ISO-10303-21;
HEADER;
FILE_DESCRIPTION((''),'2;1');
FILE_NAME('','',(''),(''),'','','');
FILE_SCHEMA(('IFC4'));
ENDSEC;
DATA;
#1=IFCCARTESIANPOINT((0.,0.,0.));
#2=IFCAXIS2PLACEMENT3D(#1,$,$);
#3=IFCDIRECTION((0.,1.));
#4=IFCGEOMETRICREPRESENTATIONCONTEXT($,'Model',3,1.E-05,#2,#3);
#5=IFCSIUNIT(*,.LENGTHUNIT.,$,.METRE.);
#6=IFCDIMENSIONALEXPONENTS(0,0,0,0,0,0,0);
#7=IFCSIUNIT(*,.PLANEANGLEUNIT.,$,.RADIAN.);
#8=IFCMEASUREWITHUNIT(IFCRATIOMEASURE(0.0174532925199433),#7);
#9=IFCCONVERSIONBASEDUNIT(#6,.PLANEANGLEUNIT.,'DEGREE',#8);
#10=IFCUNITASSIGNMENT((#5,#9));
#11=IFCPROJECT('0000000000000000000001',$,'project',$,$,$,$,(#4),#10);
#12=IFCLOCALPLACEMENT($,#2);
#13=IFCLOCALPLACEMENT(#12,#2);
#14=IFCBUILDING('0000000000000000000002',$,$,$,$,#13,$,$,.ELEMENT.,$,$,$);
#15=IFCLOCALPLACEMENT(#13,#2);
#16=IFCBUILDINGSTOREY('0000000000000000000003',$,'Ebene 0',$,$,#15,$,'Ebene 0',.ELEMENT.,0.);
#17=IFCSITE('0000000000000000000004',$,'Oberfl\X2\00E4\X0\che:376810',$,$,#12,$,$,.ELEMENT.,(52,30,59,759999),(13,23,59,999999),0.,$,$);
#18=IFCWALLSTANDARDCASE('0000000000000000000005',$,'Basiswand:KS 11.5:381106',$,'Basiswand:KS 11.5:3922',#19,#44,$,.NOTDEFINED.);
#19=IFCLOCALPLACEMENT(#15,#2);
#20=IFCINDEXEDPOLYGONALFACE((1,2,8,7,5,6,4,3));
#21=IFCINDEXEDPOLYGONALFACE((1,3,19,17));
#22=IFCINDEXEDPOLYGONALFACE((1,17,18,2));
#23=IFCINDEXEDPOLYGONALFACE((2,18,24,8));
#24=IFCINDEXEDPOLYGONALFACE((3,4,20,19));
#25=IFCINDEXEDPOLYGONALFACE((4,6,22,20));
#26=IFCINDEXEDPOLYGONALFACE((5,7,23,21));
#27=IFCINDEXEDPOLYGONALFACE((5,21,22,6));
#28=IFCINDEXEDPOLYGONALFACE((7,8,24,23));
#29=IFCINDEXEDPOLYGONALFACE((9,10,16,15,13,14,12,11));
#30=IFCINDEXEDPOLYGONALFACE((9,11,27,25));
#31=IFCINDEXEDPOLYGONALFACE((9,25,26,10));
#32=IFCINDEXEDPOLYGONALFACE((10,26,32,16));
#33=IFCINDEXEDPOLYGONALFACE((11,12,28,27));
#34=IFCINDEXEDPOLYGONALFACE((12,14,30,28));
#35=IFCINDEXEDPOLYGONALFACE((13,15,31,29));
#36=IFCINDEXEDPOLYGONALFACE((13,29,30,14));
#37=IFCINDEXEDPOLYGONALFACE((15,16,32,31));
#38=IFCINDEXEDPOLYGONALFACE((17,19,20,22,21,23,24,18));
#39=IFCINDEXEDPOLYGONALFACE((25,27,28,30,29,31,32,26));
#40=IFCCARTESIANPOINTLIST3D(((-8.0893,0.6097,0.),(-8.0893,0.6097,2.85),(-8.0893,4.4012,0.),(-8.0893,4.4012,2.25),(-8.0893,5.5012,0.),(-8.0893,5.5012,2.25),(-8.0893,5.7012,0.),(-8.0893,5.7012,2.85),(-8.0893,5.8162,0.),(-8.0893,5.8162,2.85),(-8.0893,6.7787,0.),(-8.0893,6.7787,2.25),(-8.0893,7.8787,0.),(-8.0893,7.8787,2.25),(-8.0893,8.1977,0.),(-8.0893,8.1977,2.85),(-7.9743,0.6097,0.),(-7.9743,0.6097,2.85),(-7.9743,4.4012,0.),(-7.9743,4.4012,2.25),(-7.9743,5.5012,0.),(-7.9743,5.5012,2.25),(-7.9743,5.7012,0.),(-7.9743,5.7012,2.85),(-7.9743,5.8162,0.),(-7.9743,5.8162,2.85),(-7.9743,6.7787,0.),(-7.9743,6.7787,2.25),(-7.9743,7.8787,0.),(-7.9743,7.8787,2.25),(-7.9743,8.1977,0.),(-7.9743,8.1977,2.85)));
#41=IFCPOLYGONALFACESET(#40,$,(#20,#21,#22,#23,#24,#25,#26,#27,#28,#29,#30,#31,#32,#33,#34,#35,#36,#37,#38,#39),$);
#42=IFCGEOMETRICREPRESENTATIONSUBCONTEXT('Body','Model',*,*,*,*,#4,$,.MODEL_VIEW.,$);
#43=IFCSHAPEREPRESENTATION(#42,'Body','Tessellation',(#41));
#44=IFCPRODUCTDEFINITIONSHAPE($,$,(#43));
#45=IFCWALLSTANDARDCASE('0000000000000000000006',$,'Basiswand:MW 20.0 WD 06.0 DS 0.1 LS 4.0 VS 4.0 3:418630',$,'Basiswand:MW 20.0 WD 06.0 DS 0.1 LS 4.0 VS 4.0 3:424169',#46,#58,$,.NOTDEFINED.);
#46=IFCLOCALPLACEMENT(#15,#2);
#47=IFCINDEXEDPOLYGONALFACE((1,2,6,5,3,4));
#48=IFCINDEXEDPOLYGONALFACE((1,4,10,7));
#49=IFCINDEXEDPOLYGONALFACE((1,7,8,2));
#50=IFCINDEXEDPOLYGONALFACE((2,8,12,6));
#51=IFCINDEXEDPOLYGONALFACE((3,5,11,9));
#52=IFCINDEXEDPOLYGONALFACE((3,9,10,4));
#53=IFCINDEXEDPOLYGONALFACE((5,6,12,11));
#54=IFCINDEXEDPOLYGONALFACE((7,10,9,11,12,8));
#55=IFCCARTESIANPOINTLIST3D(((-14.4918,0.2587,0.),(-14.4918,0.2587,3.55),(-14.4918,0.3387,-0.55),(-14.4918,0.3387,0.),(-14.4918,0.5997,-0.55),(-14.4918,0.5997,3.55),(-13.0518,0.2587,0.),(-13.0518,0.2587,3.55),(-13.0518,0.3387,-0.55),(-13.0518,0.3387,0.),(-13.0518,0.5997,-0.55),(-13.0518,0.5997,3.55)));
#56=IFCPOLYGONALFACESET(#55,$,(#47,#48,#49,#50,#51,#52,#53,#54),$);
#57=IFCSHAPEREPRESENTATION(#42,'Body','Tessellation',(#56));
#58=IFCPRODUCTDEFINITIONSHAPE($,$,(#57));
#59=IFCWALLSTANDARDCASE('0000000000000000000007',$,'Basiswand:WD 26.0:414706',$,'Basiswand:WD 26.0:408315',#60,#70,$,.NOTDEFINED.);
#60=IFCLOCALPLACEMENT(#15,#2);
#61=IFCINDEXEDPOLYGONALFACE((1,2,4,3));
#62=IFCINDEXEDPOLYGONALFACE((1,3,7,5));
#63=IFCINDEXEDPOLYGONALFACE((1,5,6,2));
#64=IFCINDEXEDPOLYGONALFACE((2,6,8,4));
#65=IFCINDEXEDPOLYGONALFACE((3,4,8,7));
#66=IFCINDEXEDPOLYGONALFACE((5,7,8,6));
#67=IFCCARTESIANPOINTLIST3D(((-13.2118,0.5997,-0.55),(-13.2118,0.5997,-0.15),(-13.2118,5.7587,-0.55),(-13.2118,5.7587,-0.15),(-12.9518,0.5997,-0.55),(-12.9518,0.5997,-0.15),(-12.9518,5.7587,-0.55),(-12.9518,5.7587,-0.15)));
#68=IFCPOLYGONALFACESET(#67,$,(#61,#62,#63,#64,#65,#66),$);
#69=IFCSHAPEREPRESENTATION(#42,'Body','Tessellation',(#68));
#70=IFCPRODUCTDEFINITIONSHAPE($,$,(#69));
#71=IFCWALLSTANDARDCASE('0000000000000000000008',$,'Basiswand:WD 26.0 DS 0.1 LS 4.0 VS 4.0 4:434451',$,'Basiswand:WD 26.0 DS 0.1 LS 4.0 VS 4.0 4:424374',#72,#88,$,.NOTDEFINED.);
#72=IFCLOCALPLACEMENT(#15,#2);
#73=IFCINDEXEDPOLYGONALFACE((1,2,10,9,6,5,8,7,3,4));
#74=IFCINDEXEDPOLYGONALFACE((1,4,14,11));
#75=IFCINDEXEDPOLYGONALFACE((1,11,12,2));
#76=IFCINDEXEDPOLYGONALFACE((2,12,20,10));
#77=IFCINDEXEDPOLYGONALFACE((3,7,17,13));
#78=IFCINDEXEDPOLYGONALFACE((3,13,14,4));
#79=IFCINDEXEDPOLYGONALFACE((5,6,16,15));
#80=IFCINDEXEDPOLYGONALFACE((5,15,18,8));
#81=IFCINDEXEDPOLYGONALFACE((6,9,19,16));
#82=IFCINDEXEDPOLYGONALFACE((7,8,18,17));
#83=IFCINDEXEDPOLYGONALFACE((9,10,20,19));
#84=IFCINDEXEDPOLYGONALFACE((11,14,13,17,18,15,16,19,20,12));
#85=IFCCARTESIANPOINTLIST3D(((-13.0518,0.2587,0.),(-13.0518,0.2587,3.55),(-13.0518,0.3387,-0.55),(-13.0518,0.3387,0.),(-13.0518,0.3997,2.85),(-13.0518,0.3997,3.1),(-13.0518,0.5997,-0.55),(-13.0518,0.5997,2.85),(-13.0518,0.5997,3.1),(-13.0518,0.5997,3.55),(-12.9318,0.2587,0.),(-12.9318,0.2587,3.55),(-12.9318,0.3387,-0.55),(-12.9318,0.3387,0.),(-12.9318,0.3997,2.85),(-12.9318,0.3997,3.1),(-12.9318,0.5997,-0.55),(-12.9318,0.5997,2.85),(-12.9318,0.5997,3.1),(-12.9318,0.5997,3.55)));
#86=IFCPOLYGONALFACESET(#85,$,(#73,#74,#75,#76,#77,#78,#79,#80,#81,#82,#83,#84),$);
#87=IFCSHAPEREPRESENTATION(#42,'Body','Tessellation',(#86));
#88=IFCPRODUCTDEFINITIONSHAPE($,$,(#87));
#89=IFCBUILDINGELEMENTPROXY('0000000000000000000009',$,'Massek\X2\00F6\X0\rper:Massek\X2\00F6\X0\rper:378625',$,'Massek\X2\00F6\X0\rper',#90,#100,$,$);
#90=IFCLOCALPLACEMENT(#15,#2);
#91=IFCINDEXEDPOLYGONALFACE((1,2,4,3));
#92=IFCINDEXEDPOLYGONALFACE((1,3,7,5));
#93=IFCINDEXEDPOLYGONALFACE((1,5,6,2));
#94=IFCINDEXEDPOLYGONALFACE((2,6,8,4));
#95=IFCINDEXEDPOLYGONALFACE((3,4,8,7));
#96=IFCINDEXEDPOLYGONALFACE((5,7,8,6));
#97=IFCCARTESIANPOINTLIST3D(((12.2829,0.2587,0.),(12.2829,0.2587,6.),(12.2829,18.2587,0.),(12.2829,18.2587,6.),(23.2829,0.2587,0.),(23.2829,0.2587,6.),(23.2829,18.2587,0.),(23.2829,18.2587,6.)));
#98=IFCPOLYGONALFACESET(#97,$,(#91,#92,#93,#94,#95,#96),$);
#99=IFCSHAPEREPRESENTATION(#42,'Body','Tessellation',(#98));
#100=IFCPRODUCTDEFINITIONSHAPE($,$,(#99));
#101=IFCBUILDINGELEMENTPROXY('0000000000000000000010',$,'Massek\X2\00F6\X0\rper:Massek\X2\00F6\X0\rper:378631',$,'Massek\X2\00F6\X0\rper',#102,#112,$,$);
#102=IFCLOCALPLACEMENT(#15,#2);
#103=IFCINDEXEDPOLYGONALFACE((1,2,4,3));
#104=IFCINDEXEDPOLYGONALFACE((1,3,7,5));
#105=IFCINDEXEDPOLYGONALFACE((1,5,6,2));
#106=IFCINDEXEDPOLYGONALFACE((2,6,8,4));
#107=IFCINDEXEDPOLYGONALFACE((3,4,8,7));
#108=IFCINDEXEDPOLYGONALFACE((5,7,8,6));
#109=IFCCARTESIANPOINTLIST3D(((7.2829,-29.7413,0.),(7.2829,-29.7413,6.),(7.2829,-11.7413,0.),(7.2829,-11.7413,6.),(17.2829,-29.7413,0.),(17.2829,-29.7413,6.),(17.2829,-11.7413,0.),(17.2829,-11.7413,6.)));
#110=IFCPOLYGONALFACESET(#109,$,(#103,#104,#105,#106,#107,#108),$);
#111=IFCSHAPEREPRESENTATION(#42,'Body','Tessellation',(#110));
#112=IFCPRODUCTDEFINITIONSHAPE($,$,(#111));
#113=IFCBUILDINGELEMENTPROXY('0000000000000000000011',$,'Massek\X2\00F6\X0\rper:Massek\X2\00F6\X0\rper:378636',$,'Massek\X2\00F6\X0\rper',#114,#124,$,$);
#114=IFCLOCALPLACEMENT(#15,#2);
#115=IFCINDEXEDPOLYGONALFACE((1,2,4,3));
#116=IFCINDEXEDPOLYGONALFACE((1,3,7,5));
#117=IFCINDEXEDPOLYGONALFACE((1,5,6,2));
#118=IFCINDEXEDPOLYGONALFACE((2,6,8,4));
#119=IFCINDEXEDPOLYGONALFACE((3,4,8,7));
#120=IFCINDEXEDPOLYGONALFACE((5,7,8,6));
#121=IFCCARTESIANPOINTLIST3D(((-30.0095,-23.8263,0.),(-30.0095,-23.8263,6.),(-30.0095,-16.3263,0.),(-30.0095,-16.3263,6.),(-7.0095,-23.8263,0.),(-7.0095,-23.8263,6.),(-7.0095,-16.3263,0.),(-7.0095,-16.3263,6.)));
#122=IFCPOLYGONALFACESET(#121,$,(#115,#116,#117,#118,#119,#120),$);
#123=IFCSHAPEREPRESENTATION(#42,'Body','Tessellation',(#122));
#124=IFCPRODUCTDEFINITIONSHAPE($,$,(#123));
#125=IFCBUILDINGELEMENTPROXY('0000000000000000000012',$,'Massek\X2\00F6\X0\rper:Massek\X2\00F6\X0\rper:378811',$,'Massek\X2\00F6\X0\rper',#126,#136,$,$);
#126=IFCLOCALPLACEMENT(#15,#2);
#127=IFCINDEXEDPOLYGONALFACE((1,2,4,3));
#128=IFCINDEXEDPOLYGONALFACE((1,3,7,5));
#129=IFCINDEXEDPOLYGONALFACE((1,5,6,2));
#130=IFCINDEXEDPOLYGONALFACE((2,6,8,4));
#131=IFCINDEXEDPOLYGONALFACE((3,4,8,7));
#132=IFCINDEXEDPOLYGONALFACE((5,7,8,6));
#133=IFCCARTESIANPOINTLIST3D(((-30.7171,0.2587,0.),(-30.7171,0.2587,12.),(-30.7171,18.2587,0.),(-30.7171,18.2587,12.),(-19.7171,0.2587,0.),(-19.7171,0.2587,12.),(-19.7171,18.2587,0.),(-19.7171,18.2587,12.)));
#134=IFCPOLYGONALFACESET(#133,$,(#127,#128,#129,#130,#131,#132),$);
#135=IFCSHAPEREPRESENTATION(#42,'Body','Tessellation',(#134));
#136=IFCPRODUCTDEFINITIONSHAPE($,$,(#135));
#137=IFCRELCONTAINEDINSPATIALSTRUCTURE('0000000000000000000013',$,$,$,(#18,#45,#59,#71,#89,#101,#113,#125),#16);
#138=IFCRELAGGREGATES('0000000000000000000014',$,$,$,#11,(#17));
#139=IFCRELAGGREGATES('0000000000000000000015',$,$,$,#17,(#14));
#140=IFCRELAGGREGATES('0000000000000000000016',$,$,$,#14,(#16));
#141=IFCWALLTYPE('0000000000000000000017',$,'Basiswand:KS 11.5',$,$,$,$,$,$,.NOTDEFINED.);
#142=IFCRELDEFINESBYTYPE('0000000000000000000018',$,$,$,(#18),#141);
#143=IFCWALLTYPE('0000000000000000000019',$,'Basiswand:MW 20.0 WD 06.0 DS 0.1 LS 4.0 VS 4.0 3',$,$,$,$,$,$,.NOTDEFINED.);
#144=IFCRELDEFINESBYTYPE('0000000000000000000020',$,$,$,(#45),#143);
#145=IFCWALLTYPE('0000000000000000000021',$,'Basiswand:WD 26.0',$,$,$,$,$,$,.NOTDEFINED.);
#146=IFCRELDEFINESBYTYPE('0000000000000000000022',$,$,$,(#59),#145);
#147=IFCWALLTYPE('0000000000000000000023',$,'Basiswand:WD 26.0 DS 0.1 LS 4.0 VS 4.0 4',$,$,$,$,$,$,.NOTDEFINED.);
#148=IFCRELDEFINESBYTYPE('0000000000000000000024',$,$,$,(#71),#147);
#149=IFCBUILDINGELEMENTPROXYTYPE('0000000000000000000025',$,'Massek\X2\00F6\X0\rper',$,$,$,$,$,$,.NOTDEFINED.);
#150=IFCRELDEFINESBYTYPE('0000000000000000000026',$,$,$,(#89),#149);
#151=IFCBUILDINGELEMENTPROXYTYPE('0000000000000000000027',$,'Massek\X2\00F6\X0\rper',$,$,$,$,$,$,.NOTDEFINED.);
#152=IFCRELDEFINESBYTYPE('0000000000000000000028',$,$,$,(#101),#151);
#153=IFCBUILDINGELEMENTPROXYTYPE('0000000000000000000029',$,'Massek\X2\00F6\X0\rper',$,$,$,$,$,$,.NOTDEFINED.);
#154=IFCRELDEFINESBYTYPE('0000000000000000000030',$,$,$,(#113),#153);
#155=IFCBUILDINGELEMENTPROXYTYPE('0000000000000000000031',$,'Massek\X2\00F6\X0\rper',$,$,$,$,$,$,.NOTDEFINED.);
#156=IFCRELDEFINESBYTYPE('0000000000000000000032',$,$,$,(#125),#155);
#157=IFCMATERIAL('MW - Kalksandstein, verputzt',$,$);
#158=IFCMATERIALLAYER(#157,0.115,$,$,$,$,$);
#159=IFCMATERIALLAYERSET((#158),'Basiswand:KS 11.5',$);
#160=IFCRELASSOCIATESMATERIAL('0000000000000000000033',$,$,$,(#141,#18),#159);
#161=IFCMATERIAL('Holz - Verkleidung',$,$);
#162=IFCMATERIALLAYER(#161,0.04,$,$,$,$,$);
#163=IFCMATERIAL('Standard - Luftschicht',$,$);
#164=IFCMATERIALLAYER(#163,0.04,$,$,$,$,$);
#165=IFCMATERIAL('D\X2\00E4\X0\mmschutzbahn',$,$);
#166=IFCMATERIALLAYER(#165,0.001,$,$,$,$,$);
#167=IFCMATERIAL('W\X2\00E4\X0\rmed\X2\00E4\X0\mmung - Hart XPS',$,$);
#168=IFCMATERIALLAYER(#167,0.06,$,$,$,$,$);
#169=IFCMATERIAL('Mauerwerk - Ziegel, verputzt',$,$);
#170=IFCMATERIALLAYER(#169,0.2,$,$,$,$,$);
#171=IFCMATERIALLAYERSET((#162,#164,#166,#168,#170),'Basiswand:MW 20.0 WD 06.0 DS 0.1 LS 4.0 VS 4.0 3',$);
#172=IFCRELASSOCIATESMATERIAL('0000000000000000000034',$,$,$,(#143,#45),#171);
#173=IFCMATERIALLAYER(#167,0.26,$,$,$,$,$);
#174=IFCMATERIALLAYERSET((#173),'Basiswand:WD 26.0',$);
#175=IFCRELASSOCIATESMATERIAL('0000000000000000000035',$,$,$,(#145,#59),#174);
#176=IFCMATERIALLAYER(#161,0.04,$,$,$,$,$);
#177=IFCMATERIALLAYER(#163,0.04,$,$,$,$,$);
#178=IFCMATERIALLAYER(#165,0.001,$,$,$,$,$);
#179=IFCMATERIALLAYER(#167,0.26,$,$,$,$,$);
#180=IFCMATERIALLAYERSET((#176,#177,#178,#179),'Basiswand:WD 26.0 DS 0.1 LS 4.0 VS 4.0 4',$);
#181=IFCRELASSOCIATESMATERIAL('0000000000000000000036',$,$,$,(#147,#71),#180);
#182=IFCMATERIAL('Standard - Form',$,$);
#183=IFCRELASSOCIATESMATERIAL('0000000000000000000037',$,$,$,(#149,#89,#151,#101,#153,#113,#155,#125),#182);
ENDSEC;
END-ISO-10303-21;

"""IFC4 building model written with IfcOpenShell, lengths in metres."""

from ifc_helpers import new_model, entity, si_unit, converted_unit, direction, frame, frame_2d, origin, origin_2d_with_axis, place, context, subcontext, project, spatial, polyline, rectangle, extrude, clip, bounded_halfspace, source, transform, mapped, material, layer, layer_set, layer_usage, type_object, type_shapes, element, save


model = new_model("IFC4")

# Units and contexts
model_context = context("Model", 3, precision=1e-05, world=origin(), true_north=direction((0.0, 1.0)))
body_context = subcontext(model_context, "Body", "Model", "MODEL_VIEW")
ifc_project = project(units=[si_unit("LENGTHUNIT", "METRE"), converted_unit("PLANEANGLEUNIT", "DEGREE", entity("IfcRatioMeasure", 0.0174532925199433), si_unit("PLANEANGLEUNIT", "RADIAN"), dimensions=[0, 0, 0, 0, 0, 0, 0])], contexts=[model_context])

# Site, building, storey
site_placement = place(None, origin())
site = spatial("IfcSite", under=ifc_project, at=site_placement, Name="Oberfläche:376810", CompositionType="ELEMENT", RefLatitude=(52, 30, 59, 759999), RefLongitude=(13, 23, 59, 999999), RefElevation=0.0)
building_placement = place(site_placement, origin())
building = spatial("IfcBuilding", under=site, at=building_placement, CompositionType="ELEMENT")
storey_placement = place(building_placement, origin())
storey = spatial("IfcBuildingStorey", under=building, at=storey_placement, Name="Ebene 0", LongName="Ebene 0", CompositionType="ELEMENT", Elevation=0.0)

# Shared definitions
ifc_material_1 = material(Name="Wärmedämmung - Hart XPS")

# Shared definitions
ifc_material_2 = material(Name="MW - Kalksandstein, verputzt")
ifc_layer_1 = layer(ifc_material_2, 0.115)
ifc_layer_set_1 = layer_set([ifc_layer_1], Name="Basiswand:KS 11.5")
wall_type_1 = type_object("IfcWallType", Name="Basiswand:KS 11.5", PredefinedType="NOTDEFINED", material=ifc_layer_set_1)

# Wall, openings
ifc_layer_usage_1 = layer_usage(ifc_layer_set_1, "AXIS2", "NEGATIVE", 0.0575)
wall_1_placement = place(storey_placement, frame((-8.0318, 0.6097, 0.0), z_axis=(0.0, 0.0, 1.0), x_axis=(0.0, 1.0, 0.0)))
wall_1 = element("IfcWallStandardCase", 1, at=wall_1_placement, inside=storey, type_object=wall_type_1, material=ifc_layer_usage_1, Name="Basiswand:KS 11.5:381106", ObjectType="Basiswand:KS 11.5:3922", PredefinedType="NOTDEFINED", context=body_context, shape_type="SweptSolid", body=[
    extrude(rectangle(XDim=7.588, YDim=0.115, at=frame_2d((3.794, 0.0), x_axis=(-1.0, 0.0))), origin(), (0.0, 0.0, 1.0), 2.85),
])
opening_1_placement = place(storey_placement, frame((-8.0318, 0.6097, 0.0), z_axis=(0.0, 0.0, 1.0), x_axis=(0.0, 1.0, 0.0)))
element("IfcOpeningElement", 2, at=opening_1_placement, cuts=wall_1, ObjectType="Opening", PredefinedType="OPENING", context=body_context, shape_type="SweptSolid", body=[
    extrude(rectangle(XDim=2.85, YDim=0.115, at=frame_2d((0.0, 0.0), x_axis=(1.0, 0.0))), frame((5.0915, 0.0, 1.425), z_axis=(1.0, 0.0, 0.0), x_axis=(0.0, 0.0, -1.0)), (0.0, 0.0, 1.0), 0.115),
])
opening_2_placement = place(wall_1_placement, frame((7.269, 0.0575, 0.0)))
element("IfcOpeningElement", 3, at=opening_2_placement, cuts=wall_1, ObjectType="Opening", PredefinedType="OPENING", context=body_context, shape_type="SweptSolid", body=[
    extrude(rectangle(XDim=2.25, YDim=1.1, at=frame_2d((1.125, 0.55), x_axis=(1.0, 0.0))), frame((0.0, 0.0, 0.0), z_axis=(0.0, -1.0, 0.0), x_axis=(0.0, 0.0, 1.0)), (0.0, 0.0, 1.0), 0.115),
])
opening_3_placement = place(wall_1_placement, frame((4.8915, 0.0575, 0.0)))
element("IfcOpeningElement", 4, at=opening_3_placement, cuts=wall_1, ObjectType="Opening", PredefinedType="OPENING", context=body_context, shape_type="SweptSolid", body=[
    extrude(rectangle(XDim=2.25, YDim=1.1, at=frame_2d((1.125, 0.55), x_axis=(1.0, 0.0))), frame((0.0, 0.0, 0.0), z_axis=(0.0, -1.0, 0.0), x_axis=(0.0, 0.0, 1.0)), (0.0, 0.0, 1.0), 0.115),
])

# Walls
ifc_material_3 = material(Name="Holz - Verkleidung")
ifc_layer_2 = layer(ifc_material_3, 0.04)
ifc_material_4 = material(Name="Standard - Luftschicht")
ifc_layer_3 = layer(ifc_material_4, 0.04)
ifc_material_5 = material(Name="Dämmschutzbahn")
ifc_layer_4 = layer(ifc_material_5, 0.001)
ifc_layer_5 = layer(ifc_material_1, 0.06)
ifc_material_6 = material(Name="Mauerwerk - Ziegel, verputzt")
ifc_layer_6 = layer(ifc_material_6, 0.2)
ifc_layer_set_2 = layer_set([ifc_layer_2, ifc_layer_3, ifc_layer_4, ifc_layer_5, ifc_layer_6], Name="Basiswand:MW 20.0 WD 06.0 DS 0.1 LS 4.0 VS 4.0 3")
ifc_layer_usage_2 = layer_usage(ifc_layer_set_2, "AXIS2", "NEGATIVE", 0.1705)
wall_type_2 = type_object("IfcWallType", Name="Basiswand:MW 20.0 WD 06.0 DS 0.1 LS 4.0 VS 4.0 3", PredefinedType="NOTDEFINED", material=ifc_layer_set_2)
wall_2_placement = place(storey_placement, frame((-13.0518, 0.4292, -0.55), z_axis=(0.0, 0.0, 1.0), x_axis=(-1.0, 0.0, 0.0)))
element("IfcWallStandardCase", 5, at=wall_2_placement, inside=storey, type_object=wall_type_2, material=ifc_layer_usage_2, Name="Basiswand:MW 20.0 WD 06.0 DS 0.1 LS 4.0 VS 4.0 3:418630", ObjectType="Basiswand:MW 20.0 WD 06.0 DS 0.1 LS 4.0 VS 4.0 3:424169", PredefinedType="NOTDEFINED", context=body_context, shape_type="Clipping", body=[
    clip(extrude(rectangle(XDim=1.44, YDim=0.341, at=frame_2d((0.72, 0.0), x_axis=(-1.0, 0.0))), origin(), (0.0, 0.0, 1.0), 4.1), bounded_halfspace(frame((0.0, 0.0905, 0.55), z_axis=(0.0, 0.0, 1.0), x_axis=(-1.0, 0.0, 0.0)), True, frame((0.0, 0.0905, 0.55)), polyline([(0.0, 0.0), (1.44, 0.0), (1.44, 0.08), (0.0, 0.08), (0.0, 0.0)]))),
])
ifc_layer_7 = layer(ifc_material_1, 0.26)
ifc_layer_set_3 = layer_set([ifc_layer_7], Name="Basiswand:WD 26.0")
ifc_layer_usage_3 = layer_usage(ifc_layer_set_3, "AXIS2", "NEGATIVE", 0.13)
wall_type_3 = type_object("IfcWallType", Name="Basiswand:WD 26.0", PredefinedType="NOTDEFINED", material=ifc_layer_set_3)
wall_3_placement = place(storey_placement, frame((-13.0818, 0.5997, -0.55), z_axis=(0.0, 0.0, 1.0), x_axis=(0.0, 1.0, 0.0)))
element("IfcWallStandardCase", 6, at=wall_3_placement, inside=storey, type_object=wall_type_3, material=ifc_layer_usage_3, Name="Basiswand:WD 26.0:414706", ObjectType="Basiswand:WD 26.0:408315", PredefinedType="NOTDEFINED", context=body_context, shape_type="SweptSolid", body=[
    extrude(rectangle(XDim=5.159, YDim=0.26, at=frame_2d((2.5795, 0.0), x_axis=(-1.0, 0.0))), origin(), (0.0, 0.0, 1.0), 0.4),
])

# Wall, opening
ifc_layer_8 = layer(ifc_material_3, 0.04)
ifc_layer_9 = layer(ifc_material_4, 0.04)
ifc_layer_10 = layer(ifc_material_5, 0.001)
ifc_layer_11 = layer(ifc_material_1, 0.26)
ifc_layer_set_4 = layer_set([ifc_layer_8, ifc_layer_9, ifc_layer_10, ifc_layer_11], Name="Basiswand:WD 26.0 DS 0.1 LS 4.0 VS 4.0 4")
ifc_layer_usage_4 = layer_usage(ifc_layer_set_4, "AXIS2", "NEGATIVE", 0.1705)
wall_type_4 = type_object("IfcWallType", Name="Basiswand:WD 26.0 DS 0.1 LS 4.0 VS 4.0 4", PredefinedType="NOTDEFINED", material=ifc_layer_set_4)
wall_4_placement = place(storey_placement, frame((-12.9318, 0.4292, -0.55), z_axis=(0.0, 0.0, 1.0), x_axis=(-1.0, 0.0, 0.0)))
wall_4 = element("IfcWallStandardCase", 7, at=wall_4_placement, inside=storey, type_object=wall_type_4, material=ifc_layer_usage_4, Name="Basiswand:WD 26.0 DS 0.1 LS 4.0 VS 4.0 4:434451", ObjectType="Basiswand:WD 26.0 DS 0.1 LS 4.0 VS 4.0 4:424374", PredefinedType="NOTDEFINED", context=body_context, shape_type="Clipping", body=[
    clip(clip(clip(extrude(rectangle(XDim=0.12, YDim=0.341, at=frame_2d((0.06, 0.0), x_axis=(-1.0, 0.0))), origin(), (0.0, 0.0, 1.0), 4.1), bounded_halfspace(frame((0.0, 0.0905, 0.55), z_axis=(0.0, 0.0, 1.0), x_axis=(-1.0, 0.0, 0.0)), True, frame((0.0, 0.0905, 0.55)), polyline([(0.0, 0.0), (0.12, 0.0), (0.12, 0.08), (0.0, 0.08), (0.0, 0.0)]))), bounded_halfspace(frame((0.0, 0.0295, 3.4), z_axis=(0.0, 1.0, 0.0), x_axis=(0.0, 0.0, 1.0)), True, frame((0.0, 0.0295, 3.4), z_axis=(0.0, 1.0, 0.0), x_axis=(0.0, 0.0, 1.0)), polyline([(0.0, 0.0), (0.25, 0.0), (0.25, 0.12), (0.0, 0.12), (0.0, 0.0)]))), bounded_halfspace(frame((0.12, -0.1705, 3.4), z_axis=(-1.0, 0.0, 0.0), x_axis=(0.0, 1.0, 0.0)), True, frame((0.12, -0.1705, 3.4), z_axis=(-1.0, 0.0, 0.0), x_axis=(0.0, 1.0, 0.0)), polyline([(0.0, 0.0), (0.2, 0.0), (0.2, -0.25), (0.0, -0.25), (0.0, -0.7), (0.341, -0.7), (0.341, 2.85), (0.261, 2.85), (0.261, 3.4), (0.0, 3.4), (0.0, 0.0)]))),
])
opening_4_placement = place(wall_4_placement, frame((1.56, 0.3229, 0.0)))
element("IfcOpeningElement", 8, at=opening_4_placement, cuts=wall_4, ObjectType="Opening", PredefinedType="OPENING", context=body_context, shape_type="SweptSolid", body=[
    extrude(rectangle(XDim=4.1, YDim=1.44, at=frame_2d((0.0, 0.0), x_axis=(1.0, 0.0))), frame((-0.72, -0.6458, 2.05), z_axis=(0.0, 1.0, 0.0), x_axis=(0.0, 0.0, 1.0)), (0.0, 0.0, 1.0), 0.6458),
])

# Building element proxies
ifc_material_7 = material(Name="Standard - Form")
building_element_proxy_type_1 = type_object("IfcBuildingElementProxyType", Name="Massekörper", PredefinedType="NOTDEFINED", material=ifc_material_7)
shared_shape_1 = source(origin(), body_context, "Body", "SweptSolid", [
    extrude(rectangle(XDim=18.0, YDim=11.0, at=frame_2d((0.0, 0.0), x_axis=(1.0, 0.0))), frame((5.5, 9.0, 0.0), z_axis=(0.0, 0.0, 1.0), x_axis=(0.0, 1.0, 0.0)), (0.0, 0.0, 1.0), 6.0),
])
type_shapes(building_element_proxy_type_1, [shared_shape_1])
proxy_1_placement = place(storey_placement, frame((12.2829, 0.2587, 0.0)))
element("IfcBuildingElementProxy", 9, at=proxy_1_placement, inside=storey, type_object=building_element_proxy_type_1, material=ifc_material_7, Name="Massekörper:Massekörper:378625", ObjectType="Massekörper", context=body_context, shape_type="MappedRepresentation", body=[
    mapped(shared_shape_1, transform((0.0, 0.0, 0.0), scale=1.0)),
])
building_element_proxy_type_2 = type_object("IfcBuildingElementProxyType", Name="Massekörper", PredefinedType="NOTDEFINED", material=ifc_material_7)
shared_shape_2 = source(origin(), body_context, "Body", "SweptSolid", [
    extrude(rectangle(XDim=18.0, YDim=10.0, at=origin_2d_with_axis()), frame((5.0, 9.0, 0.0), z_axis=(0.0, 0.0, 1.0), x_axis=(0.0, 1.0, 0.0)), (0.0, 0.0, 1.0), 6.0),
])
type_shapes(building_element_proxy_type_2, [shared_shape_2])
proxy_2_placement = place(storey_placement, frame((7.2829, -29.7413, 0.0)))
element("IfcBuildingElementProxy", 10, at=proxy_2_placement, inside=storey, type_object=building_element_proxy_type_2, material=ifc_material_7, Name="Massekörper:Massekörper:378631", ObjectType="Massekörper", context=body_context, shape_type="MappedRepresentation", body=[
    mapped(shared_shape_2, transform((0.0, 0.0, 0.0), scale=1.0)),
])
building_element_proxy_type_3 = type_object("IfcBuildingElementProxyType", Name="Massekörper", PredefinedType="NOTDEFINED", material=ifc_material_7)
shared_shape_3 = source(origin(), body_context, "Body", "SweptSolid", [
    extrude(rectangle(XDim=7.5, YDim=23.0, at=origin_2d_with_axis()), frame((11.5, 3.75, 0.0), z_axis=(0.0, 0.0, 1.0), x_axis=(0.0, 1.0, 0.0)), (0.0, 0.0, 1.0), 6.0),
])
type_shapes(building_element_proxy_type_3, [shared_shape_3])
proxy_3_placement = place(storey_placement, frame((-30.0095, -23.8263, 0.0)))
element("IfcBuildingElementProxy", 11, at=proxy_3_placement, inside=storey, type_object=building_element_proxy_type_3, material=ifc_material_7, Name="Massekörper:Massekörper:378636", ObjectType="Massekörper", context=body_context, shape_type="MappedRepresentation", body=[
    mapped(shared_shape_3, transform((0.0, 0.0, 0.0), scale=1.0)),
])
building_element_proxy_type_4 = type_object("IfcBuildingElementProxyType", Name="Massekörper", PredefinedType="NOTDEFINED", material=ifc_material_7)
shared_shape_4 = source(origin(), body_context, "Body", "SweptSolid", [
    extrude(rectangle(XDim=18.0, YDim=11.0, at=origin_2d_with_axis()), frame((5.5, 9.0, 0.0), z_axis=(0.0, 0.0, 1.0), x_axis=(0.0, 1.0, 0.0)), (0.0, 0.0, 1.0), 12.0),
])
type_shapes(building_element_proxy_type_4, [shared_shape_4])
proxy_4_placement = place(storey_placement, frame((-30.7171, 0.2587, 0.0)))
element("IfcBuildingElementProxy", 12, at=proxy_4_placement, inside=storey, type_object=building_element_proxy_type_4, material=ifc_material_7, Name="Massekörper:Massekörper:378811", ObjectType="Massekörper", context=body_context, shape_type="MappedRepresentation", body=[
    mapped(shared_shape_4, transform((0.0, 0.0, 0.0), scale=1.0)),
])

save(model, "model.ifc")
